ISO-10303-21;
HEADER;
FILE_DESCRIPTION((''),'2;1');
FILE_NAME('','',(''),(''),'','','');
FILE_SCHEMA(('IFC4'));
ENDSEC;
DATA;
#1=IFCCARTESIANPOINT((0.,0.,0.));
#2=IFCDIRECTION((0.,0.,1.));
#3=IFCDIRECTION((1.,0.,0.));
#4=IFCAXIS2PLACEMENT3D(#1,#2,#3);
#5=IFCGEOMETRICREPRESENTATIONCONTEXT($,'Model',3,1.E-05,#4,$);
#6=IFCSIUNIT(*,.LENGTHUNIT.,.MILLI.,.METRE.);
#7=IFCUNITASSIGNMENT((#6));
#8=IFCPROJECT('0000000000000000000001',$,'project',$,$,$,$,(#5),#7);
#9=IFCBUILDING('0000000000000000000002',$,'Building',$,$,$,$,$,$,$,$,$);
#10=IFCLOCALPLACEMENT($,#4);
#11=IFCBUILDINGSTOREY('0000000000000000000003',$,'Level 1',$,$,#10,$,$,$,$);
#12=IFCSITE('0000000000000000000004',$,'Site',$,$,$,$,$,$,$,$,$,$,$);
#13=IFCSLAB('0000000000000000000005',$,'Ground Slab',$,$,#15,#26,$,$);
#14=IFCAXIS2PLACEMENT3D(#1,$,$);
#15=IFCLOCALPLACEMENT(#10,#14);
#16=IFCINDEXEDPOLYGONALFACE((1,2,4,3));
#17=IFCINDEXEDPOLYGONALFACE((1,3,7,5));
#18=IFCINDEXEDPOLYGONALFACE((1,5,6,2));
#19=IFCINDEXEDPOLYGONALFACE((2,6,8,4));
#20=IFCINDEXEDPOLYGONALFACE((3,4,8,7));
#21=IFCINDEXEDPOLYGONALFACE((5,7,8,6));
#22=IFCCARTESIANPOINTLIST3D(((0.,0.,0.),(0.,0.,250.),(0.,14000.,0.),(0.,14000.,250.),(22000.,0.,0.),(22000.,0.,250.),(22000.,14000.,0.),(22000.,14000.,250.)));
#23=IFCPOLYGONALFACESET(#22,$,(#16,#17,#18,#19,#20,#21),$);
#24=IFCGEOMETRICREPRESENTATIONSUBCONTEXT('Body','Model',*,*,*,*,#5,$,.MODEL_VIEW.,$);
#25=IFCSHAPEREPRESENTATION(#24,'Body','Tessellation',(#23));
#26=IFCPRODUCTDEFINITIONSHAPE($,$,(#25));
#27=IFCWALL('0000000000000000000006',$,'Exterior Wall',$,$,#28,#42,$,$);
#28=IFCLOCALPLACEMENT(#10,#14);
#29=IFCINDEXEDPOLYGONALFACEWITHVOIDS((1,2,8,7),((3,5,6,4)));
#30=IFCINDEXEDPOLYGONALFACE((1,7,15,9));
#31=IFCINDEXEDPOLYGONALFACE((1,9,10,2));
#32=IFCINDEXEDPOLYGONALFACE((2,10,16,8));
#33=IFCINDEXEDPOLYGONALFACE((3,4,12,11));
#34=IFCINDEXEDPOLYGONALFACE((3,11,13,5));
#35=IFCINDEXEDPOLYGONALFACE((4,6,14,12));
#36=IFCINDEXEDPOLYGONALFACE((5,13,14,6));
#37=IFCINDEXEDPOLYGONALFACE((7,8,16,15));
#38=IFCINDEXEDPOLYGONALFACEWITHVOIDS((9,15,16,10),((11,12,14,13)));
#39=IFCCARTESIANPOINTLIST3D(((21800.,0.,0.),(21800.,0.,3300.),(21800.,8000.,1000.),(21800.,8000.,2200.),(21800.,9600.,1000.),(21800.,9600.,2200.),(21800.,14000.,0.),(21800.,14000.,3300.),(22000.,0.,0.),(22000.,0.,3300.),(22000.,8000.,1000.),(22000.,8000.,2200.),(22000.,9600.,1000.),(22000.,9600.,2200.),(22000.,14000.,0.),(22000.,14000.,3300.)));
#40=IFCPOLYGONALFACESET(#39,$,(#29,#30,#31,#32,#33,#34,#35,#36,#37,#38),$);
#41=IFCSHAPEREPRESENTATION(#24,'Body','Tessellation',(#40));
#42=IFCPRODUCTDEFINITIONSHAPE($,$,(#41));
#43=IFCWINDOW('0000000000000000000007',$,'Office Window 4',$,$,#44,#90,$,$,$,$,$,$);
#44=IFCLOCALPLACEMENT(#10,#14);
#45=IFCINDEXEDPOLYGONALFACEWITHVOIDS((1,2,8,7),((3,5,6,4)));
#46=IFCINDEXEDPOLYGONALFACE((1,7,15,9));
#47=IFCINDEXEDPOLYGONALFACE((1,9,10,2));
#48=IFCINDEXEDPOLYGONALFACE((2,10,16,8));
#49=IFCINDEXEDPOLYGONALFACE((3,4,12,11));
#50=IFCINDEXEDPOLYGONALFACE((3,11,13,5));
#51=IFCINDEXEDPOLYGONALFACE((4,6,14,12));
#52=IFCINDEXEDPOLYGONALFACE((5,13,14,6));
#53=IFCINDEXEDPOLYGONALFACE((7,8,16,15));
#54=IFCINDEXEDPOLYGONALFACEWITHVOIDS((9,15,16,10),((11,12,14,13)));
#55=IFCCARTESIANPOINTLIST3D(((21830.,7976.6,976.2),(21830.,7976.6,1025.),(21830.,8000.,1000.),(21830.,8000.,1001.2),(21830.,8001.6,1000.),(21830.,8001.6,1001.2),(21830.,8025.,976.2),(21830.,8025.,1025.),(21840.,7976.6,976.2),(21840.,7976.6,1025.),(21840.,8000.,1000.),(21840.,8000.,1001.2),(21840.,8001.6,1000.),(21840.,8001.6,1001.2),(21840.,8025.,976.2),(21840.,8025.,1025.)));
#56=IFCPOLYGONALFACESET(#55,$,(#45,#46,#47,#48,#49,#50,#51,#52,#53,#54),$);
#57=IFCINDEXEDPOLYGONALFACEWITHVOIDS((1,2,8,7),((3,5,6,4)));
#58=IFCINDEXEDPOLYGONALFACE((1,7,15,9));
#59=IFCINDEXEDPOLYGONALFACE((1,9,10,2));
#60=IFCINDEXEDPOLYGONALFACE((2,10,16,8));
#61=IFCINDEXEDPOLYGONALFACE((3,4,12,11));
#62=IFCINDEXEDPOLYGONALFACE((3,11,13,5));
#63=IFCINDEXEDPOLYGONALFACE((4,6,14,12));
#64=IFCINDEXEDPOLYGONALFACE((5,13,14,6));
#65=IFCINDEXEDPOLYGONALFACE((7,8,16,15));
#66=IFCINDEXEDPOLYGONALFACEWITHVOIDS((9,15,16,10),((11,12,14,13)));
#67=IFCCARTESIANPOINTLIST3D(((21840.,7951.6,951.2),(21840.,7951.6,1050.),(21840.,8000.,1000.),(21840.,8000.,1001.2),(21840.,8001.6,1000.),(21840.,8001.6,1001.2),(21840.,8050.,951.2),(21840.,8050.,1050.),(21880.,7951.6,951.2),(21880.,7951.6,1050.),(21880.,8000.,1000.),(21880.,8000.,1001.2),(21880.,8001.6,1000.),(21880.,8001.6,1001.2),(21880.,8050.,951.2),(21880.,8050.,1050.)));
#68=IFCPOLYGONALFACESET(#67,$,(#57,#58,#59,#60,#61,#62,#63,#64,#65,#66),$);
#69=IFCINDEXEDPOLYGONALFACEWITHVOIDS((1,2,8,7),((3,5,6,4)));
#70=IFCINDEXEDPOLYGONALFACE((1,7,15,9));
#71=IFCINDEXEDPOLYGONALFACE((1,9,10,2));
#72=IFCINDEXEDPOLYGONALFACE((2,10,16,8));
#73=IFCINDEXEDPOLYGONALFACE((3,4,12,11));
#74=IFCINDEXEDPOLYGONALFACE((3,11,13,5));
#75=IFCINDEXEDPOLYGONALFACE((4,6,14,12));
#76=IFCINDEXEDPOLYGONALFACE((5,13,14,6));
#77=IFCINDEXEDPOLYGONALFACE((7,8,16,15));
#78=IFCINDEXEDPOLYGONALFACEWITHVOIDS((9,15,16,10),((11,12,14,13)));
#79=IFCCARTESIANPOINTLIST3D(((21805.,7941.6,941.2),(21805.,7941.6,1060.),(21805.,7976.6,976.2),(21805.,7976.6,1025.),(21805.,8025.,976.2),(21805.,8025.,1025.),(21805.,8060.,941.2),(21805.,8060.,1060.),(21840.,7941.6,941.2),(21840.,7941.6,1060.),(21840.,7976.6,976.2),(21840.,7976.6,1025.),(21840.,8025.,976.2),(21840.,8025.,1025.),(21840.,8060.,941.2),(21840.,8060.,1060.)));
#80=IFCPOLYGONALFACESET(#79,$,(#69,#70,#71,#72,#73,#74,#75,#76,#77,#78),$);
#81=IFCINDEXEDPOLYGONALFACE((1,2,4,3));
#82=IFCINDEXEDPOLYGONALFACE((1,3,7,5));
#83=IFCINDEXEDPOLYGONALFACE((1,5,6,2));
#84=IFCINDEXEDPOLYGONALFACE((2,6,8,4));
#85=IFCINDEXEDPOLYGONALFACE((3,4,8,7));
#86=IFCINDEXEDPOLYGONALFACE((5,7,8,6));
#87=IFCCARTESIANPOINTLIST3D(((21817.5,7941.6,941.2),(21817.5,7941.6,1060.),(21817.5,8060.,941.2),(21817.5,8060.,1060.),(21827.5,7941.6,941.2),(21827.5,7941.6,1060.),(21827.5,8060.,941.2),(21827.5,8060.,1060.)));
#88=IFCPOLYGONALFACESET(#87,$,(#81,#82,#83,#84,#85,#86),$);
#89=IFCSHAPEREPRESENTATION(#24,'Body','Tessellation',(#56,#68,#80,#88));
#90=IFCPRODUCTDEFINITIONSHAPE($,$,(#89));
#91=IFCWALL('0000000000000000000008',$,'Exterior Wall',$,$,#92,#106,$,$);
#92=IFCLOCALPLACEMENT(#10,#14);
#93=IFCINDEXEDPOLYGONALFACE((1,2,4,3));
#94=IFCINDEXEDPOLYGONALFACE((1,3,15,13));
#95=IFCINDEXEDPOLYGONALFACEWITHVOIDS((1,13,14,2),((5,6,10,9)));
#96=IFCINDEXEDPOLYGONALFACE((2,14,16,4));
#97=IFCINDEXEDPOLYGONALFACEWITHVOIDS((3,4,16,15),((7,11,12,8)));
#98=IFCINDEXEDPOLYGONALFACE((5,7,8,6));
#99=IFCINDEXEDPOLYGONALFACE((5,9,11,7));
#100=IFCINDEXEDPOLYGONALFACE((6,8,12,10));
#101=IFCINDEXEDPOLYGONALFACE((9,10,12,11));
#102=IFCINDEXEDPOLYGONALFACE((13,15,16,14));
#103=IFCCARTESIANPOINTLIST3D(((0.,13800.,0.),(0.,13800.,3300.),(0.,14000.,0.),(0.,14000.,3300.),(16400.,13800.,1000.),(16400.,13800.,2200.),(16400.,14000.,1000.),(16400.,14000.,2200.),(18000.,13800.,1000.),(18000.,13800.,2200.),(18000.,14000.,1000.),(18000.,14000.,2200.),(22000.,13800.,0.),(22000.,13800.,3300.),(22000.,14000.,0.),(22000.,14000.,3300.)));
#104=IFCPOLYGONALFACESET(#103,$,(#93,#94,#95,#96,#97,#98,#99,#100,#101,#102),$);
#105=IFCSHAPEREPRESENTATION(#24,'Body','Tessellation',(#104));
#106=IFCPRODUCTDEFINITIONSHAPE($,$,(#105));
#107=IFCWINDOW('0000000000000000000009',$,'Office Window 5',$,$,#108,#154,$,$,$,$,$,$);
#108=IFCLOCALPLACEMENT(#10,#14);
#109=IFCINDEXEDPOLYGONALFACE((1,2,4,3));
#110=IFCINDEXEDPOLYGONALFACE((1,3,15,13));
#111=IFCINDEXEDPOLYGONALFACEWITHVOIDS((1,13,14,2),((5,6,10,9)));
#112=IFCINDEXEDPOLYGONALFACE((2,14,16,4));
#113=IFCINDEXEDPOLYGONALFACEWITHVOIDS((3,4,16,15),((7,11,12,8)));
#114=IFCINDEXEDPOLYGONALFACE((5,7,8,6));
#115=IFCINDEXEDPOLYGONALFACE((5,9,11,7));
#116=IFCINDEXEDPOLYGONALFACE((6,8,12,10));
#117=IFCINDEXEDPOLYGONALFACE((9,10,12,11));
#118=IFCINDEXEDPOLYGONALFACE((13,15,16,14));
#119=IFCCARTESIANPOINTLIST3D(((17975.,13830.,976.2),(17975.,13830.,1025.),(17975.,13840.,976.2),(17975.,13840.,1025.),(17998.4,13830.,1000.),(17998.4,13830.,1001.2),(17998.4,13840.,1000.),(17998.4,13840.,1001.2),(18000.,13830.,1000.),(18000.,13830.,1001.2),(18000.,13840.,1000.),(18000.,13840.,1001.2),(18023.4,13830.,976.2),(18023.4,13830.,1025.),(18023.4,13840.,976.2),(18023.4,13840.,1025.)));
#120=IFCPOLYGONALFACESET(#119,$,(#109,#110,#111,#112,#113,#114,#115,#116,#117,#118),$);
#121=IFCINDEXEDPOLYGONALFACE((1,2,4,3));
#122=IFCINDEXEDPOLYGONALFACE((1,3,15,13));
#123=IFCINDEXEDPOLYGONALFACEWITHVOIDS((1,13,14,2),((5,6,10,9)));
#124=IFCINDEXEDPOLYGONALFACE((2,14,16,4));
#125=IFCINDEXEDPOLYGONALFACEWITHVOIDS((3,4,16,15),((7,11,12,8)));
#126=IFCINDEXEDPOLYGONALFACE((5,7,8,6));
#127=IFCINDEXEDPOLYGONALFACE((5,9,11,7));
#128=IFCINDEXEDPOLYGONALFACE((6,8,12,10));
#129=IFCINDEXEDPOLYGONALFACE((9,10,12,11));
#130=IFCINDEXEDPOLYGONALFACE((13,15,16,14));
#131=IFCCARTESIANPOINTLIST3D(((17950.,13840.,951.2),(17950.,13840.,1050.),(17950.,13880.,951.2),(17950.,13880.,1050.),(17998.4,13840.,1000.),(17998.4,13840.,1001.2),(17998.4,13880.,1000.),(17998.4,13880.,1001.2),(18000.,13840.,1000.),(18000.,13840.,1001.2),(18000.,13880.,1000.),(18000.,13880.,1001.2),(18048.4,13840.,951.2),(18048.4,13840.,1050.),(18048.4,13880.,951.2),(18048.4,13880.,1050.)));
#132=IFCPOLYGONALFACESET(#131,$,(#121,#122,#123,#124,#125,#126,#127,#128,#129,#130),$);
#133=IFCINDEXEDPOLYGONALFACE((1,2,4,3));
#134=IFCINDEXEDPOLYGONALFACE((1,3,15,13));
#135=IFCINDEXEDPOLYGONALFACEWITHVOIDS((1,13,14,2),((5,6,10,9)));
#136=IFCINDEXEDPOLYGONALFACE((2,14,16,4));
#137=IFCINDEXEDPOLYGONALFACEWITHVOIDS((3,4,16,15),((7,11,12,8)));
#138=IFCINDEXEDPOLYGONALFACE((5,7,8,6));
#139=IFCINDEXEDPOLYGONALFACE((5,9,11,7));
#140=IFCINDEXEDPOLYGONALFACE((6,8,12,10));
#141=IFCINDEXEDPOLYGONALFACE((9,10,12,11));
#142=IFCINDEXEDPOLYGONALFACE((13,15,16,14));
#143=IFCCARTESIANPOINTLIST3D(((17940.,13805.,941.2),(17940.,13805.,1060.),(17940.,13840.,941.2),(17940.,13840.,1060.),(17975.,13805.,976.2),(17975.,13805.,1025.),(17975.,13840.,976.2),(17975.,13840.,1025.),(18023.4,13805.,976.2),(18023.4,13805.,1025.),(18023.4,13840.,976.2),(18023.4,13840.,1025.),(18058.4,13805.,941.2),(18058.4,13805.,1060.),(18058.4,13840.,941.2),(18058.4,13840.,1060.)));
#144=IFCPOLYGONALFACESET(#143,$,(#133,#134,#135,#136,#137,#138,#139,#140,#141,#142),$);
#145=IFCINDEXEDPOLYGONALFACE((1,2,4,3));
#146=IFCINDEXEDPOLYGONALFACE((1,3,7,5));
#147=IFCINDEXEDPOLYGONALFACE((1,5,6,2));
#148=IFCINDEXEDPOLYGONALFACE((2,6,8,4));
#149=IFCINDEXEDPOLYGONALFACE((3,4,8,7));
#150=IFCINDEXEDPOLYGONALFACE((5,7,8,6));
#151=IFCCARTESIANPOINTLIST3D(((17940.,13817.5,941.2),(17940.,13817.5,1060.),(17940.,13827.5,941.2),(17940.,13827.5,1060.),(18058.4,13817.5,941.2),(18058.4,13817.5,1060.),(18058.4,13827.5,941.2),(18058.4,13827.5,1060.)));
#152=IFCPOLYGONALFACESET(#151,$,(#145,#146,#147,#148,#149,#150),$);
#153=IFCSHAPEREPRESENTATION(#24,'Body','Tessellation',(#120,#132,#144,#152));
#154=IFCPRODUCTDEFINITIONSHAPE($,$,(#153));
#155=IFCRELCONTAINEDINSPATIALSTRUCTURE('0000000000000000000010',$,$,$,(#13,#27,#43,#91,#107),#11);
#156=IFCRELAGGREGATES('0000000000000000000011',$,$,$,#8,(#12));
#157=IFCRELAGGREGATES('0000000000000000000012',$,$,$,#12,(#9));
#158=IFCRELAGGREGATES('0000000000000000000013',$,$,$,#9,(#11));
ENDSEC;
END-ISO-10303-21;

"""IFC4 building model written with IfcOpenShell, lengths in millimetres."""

from ifc_helpers import new_model, si_unit, frame, origin_with_axes, place, context, subcontext, project, spatial, line, indexed_curve, outline, extrude, element, fill, save


model = new_model("IFC4")

# Units and contexts
model_context = context("Model", 3, precision=1e-05, world=origin_with_axes())
body_context = subcontext(model_context, "Body", "Model", "MODEL_VIEW")
ifc_project = project(units=[si_unit("LENGTHUNIT", "METRE", prefix="MILLI")], contexts=[model_context])

# Site, building, storey
site = spatial("IfcSite", under=ifc_project, Name="Site")
building = spatial("IfcBuilding", under=site, Name="Building")
storey_placement = place(None, origin_with_axes())
storey = spatial("IfcBuildingStorey", under=building, at=storey_placement, Name="Level 1")

# Slab
slab_placement = place(storey_placement, origin_with_axes())
element("IfcSlab", 1, at=slab_placement, inside=storey, Name="Ground Slab", context=body_context, shape_type="SweptSolid", body=[
    extrude(outline(indexed_curve([(0.0, 0.0), (22000.0, 0.0), (22000.0, 14000.0), (0.0, 14000.0), (0.0, 0.0)])), None, (0.0, 0.0, 1.0), 250.0),
])

# Walls, openings, windows
wall_1_placement = place(storey_placement, frame((22000.0, 0.0, 0.0), z_axis=(0.0, 0.0, 1.0), x_axis=(0.0, 1.0, 0.0)))
wall_1 = element("IfcWall", 2, at=wall_1_placement, inside=storey, Name="Exterior Wall", context=body_context, shape_type="SweptSolid", body=[
    extrude(outline(indexed_curve([(0.0, 0.0), (0.0, 200.0), (14000.0, 200.0), (14000.0, 0.0), (0.0, 0.0)], self_intersect=False)), origin_with_axes(), (0.0, 0.0, 1.0), 3300.0),
])
opening_1_placement = place(wall_1_placement, frame((8000.0, -100.0, 1000.0), z_axis=(0.0, 0.0, 1.0), x_axis=(1.0, 0.0, 0.0)))
opening_1 = element("IfcOpeningElement", 3, at=opening_1_placement, cuts=wall_1, context=body_context, shape_type="SweptSolid", body=[
    extrude(outline(indexed_curve([(0.0, 0.0), (0.0, 400.0), (1600.0, 400.0), (1600.0, 0.0), (0.0, 0.0)], self_intersect=False)), origin_with_axes(), (0.0, 0.0, 1.0), 1200.0),
])
window_1_placement = place(opening_1_placement, frame((0.0, 170.0, 0.0), z_axis=(0.0, 0.0, 1.0), x_axis=(1.0, 0.0, 0.0)))
window_1 = element("IfcWindow", 4, at=window_1_placement, inside=storey, Name="Office Window 4", context=body_context, shape_type="SweptSolid", body=[
    extrude(outline(indexed_curve([(0.0, 0.0), (1.6, 0.0), (1.6, 1.2), (0.0, 1.2)], segments=[line(1, 2, 3, 4, 1)]), holes=[indexed_curve([(25.0, 25.0), (-23.4, 25.0), (-23.4, -23.8), (25.0, -23.8)], segments=[line(1, 2, 3, 4, 1)])]), frame((0.0, 90.0, 0.0), z_axis=(0.0, -1.0, 0.0), x_axis=(1.0, 0.0, 0.0)), (0.0, 0.0, -1.0), 10.0),
    extrude(outline(indexed_curve([(0.0, 0.0), (1.6, 0.0), (1.6, 1.2), (0.0, 1.2)], segments=[line(1, 2, 3, 4, 1)]), holes=[indexed_curve([(50.0, 50.0), (-48.4, 50.0), (-48.4, -48.8), (50.0, -48.8)], segments=[line(1, 2, 3, 4, 1)])]), frame((0.0, 50.0, 0.0), z_axis=(0.0, -1.0, 0.0), x_axis=(1.0, 0.0, 0.0)), (0.0, 0.0, -1.0), 40.0),
    extrude(outline(indexed_curve([(0.0, 0.0), (-48.4, 0.0), (-48.4, -48.8), (0.0, -48.8)], segments=[line(1, 2, 3, 4, 1)]), holes=[indexed_curve([(35.0, 35.0), (-83.4, 35.0), (-83.4, -83.8), (35.0, -83.8)], segments=[line(1, 2, 3, 4, 1)])]), frame((25.0, 90.0, 25.0), z_axis=(0.0, -1.0, 0.0), x_axis=(1.0, 0.0, 0.0)), (0.0, 0.0, -1.0), 35.0),
    extrude(outline(indexed_curve([(35.0, 35.0), (-83.4, 35.0), (-83.4, -83.8), (35.0, -83.8)], segments=[line(1, 2, 3, 4, 1)])), frame((25.0, 102.5, 25.0), z_axis=(0.0, -1.0, 0.0), x_axis=(1.0, 0.0, 0.0)), (0.0, 0.0, -1.0), 10.0),
])
fill(opening_1, window_1)
wall_2_placement = place(storey_placement, frame((22000.0, 14000.0, 0.0), z_axis=(0.0, 0.0, 1.0), x_axis=(-1.0, 0.0, 0.0)))
wall_2 = element("IfcWall", 5, at=wall_2_placement, inside=storey, Name="Exterior Wall", context=body_context, shape_type="SweptSolid", body=[
    extrude(outline(indexed_curve([(0.0, 0.0), (0.0, 200.0), (22000.0, 200.0), (22000.0, 0.0), (0.0, 0.0)], self_intersect=False)), origin_with_axes(), (0.0, 0.0, 1.0), 3300.0),
])
opening_2_placement = place(wall_2_placement, frame((4000.0, -100.0, 1000.0), z_axis=(0.0, 0.0, 1.0), x_axis=(1.0, 0.0, 0.0)))
opening_2 = element("IfcOpeningElement", 6, at=opening_2_placement, cuts=wall_2, context=body_context, shape_type="SweptSolid", body=[
    extrude(outline(indexed_curve([(0.0, 0.0), (0.0, 400.0), (1600.0, 400.0), (1600.0, 0.0), (0.0, 0.0)], self_intersect=False)), origin_with_axes(), (0.0, 0.0, 1.0), 1200.0),
])
window_2_placement = place(opening_2_placement, frame((0.0, 170.0, 0.0), z_axis=(0.0, 0.0, 1.0), x_axis=(1.0, 0.0, 0.0)))
window_2 = element("IfcWindow", 7, at=window_2_placement, inside=storey, Name="Office Window 5", context=body_context, shape_type="SweptSolid", body=[
    extrude(outline(indexed_curve([(0.0, 0.0), (1.6, 0.0), (1.6, 1.2), (0.0, 1.2)], segments=[line(1, 2, 3, 4, 1)]), holes=[indexed_curve([(25.0, 25.0), (-23.4, 25.0), (-23.4, -23.8), (25.0, -23.8)], segments=[line(1, 2, 3, 4, 1)])]), frame((0.0, 90.0, 0.0), z_axis=(0.0, -1.0, 0.0), x_axis=(1.0, 0.0, 0.0)), (0.0, 0.0, -1.0), 10.0),
    extrude(outline(indexed_curve([(0.0, 0.0), (1.6, 0.0), (1.6, 1.2), (0.0, 1.2)], segments=[line(1, 2, 3, 4, 1)]), holes=[indexed_curve([(50.0, 50.0), (-48.4, 50.0), (-48.4, -48.8), (50.0, -48.8)], segments=[line(1, 2, 3, 4, 1)])]), frame((0.0, 50.0, 0.0), z_axis=(0.0, -1.0, 0.0), x_axis=(1.0, 0.0, 0.0)), (0.0, 0.0, -1.0), 40.0),
    extrude(outline(indexed_curve([(0.0, 0.0), (-48.4, 0.0), (-48.4, -48.8), (0.0, -48.8)], segments=[line(1, 2, 3, 4, 1)]), holes=[indexed_curve([(35.0, 35.0), (-83.4, 35.0), (-83.4, -83.8), (35.0, -83.8)], segments=[line(1, 2, 3, 4, 1)])]), frame((25.0, 90.0, 25.0), z_axis=(0.0, -1.0, 0.0), x_axis=(1.0, 0.0, 0.0)), (0.0, 0.0, -1.0), 35.0),
    extrude(outline(indexed_curve([(35.0, 35.0), (-83.4, 35.0), (-83.4, -83.8), (35.0, -83.8)], segments=[line(1, 2, 3, 4, 1)])), frame((25.0, 102.5, 25.0), z_axis=(0.0, -1.0, 0.0), x_axis=(1.0, 0.0, 0.0)), (0.0, 0.0, -1.0), 10.0),
])
fill(opening_2, window_2)

save(model, "model.ifc")
